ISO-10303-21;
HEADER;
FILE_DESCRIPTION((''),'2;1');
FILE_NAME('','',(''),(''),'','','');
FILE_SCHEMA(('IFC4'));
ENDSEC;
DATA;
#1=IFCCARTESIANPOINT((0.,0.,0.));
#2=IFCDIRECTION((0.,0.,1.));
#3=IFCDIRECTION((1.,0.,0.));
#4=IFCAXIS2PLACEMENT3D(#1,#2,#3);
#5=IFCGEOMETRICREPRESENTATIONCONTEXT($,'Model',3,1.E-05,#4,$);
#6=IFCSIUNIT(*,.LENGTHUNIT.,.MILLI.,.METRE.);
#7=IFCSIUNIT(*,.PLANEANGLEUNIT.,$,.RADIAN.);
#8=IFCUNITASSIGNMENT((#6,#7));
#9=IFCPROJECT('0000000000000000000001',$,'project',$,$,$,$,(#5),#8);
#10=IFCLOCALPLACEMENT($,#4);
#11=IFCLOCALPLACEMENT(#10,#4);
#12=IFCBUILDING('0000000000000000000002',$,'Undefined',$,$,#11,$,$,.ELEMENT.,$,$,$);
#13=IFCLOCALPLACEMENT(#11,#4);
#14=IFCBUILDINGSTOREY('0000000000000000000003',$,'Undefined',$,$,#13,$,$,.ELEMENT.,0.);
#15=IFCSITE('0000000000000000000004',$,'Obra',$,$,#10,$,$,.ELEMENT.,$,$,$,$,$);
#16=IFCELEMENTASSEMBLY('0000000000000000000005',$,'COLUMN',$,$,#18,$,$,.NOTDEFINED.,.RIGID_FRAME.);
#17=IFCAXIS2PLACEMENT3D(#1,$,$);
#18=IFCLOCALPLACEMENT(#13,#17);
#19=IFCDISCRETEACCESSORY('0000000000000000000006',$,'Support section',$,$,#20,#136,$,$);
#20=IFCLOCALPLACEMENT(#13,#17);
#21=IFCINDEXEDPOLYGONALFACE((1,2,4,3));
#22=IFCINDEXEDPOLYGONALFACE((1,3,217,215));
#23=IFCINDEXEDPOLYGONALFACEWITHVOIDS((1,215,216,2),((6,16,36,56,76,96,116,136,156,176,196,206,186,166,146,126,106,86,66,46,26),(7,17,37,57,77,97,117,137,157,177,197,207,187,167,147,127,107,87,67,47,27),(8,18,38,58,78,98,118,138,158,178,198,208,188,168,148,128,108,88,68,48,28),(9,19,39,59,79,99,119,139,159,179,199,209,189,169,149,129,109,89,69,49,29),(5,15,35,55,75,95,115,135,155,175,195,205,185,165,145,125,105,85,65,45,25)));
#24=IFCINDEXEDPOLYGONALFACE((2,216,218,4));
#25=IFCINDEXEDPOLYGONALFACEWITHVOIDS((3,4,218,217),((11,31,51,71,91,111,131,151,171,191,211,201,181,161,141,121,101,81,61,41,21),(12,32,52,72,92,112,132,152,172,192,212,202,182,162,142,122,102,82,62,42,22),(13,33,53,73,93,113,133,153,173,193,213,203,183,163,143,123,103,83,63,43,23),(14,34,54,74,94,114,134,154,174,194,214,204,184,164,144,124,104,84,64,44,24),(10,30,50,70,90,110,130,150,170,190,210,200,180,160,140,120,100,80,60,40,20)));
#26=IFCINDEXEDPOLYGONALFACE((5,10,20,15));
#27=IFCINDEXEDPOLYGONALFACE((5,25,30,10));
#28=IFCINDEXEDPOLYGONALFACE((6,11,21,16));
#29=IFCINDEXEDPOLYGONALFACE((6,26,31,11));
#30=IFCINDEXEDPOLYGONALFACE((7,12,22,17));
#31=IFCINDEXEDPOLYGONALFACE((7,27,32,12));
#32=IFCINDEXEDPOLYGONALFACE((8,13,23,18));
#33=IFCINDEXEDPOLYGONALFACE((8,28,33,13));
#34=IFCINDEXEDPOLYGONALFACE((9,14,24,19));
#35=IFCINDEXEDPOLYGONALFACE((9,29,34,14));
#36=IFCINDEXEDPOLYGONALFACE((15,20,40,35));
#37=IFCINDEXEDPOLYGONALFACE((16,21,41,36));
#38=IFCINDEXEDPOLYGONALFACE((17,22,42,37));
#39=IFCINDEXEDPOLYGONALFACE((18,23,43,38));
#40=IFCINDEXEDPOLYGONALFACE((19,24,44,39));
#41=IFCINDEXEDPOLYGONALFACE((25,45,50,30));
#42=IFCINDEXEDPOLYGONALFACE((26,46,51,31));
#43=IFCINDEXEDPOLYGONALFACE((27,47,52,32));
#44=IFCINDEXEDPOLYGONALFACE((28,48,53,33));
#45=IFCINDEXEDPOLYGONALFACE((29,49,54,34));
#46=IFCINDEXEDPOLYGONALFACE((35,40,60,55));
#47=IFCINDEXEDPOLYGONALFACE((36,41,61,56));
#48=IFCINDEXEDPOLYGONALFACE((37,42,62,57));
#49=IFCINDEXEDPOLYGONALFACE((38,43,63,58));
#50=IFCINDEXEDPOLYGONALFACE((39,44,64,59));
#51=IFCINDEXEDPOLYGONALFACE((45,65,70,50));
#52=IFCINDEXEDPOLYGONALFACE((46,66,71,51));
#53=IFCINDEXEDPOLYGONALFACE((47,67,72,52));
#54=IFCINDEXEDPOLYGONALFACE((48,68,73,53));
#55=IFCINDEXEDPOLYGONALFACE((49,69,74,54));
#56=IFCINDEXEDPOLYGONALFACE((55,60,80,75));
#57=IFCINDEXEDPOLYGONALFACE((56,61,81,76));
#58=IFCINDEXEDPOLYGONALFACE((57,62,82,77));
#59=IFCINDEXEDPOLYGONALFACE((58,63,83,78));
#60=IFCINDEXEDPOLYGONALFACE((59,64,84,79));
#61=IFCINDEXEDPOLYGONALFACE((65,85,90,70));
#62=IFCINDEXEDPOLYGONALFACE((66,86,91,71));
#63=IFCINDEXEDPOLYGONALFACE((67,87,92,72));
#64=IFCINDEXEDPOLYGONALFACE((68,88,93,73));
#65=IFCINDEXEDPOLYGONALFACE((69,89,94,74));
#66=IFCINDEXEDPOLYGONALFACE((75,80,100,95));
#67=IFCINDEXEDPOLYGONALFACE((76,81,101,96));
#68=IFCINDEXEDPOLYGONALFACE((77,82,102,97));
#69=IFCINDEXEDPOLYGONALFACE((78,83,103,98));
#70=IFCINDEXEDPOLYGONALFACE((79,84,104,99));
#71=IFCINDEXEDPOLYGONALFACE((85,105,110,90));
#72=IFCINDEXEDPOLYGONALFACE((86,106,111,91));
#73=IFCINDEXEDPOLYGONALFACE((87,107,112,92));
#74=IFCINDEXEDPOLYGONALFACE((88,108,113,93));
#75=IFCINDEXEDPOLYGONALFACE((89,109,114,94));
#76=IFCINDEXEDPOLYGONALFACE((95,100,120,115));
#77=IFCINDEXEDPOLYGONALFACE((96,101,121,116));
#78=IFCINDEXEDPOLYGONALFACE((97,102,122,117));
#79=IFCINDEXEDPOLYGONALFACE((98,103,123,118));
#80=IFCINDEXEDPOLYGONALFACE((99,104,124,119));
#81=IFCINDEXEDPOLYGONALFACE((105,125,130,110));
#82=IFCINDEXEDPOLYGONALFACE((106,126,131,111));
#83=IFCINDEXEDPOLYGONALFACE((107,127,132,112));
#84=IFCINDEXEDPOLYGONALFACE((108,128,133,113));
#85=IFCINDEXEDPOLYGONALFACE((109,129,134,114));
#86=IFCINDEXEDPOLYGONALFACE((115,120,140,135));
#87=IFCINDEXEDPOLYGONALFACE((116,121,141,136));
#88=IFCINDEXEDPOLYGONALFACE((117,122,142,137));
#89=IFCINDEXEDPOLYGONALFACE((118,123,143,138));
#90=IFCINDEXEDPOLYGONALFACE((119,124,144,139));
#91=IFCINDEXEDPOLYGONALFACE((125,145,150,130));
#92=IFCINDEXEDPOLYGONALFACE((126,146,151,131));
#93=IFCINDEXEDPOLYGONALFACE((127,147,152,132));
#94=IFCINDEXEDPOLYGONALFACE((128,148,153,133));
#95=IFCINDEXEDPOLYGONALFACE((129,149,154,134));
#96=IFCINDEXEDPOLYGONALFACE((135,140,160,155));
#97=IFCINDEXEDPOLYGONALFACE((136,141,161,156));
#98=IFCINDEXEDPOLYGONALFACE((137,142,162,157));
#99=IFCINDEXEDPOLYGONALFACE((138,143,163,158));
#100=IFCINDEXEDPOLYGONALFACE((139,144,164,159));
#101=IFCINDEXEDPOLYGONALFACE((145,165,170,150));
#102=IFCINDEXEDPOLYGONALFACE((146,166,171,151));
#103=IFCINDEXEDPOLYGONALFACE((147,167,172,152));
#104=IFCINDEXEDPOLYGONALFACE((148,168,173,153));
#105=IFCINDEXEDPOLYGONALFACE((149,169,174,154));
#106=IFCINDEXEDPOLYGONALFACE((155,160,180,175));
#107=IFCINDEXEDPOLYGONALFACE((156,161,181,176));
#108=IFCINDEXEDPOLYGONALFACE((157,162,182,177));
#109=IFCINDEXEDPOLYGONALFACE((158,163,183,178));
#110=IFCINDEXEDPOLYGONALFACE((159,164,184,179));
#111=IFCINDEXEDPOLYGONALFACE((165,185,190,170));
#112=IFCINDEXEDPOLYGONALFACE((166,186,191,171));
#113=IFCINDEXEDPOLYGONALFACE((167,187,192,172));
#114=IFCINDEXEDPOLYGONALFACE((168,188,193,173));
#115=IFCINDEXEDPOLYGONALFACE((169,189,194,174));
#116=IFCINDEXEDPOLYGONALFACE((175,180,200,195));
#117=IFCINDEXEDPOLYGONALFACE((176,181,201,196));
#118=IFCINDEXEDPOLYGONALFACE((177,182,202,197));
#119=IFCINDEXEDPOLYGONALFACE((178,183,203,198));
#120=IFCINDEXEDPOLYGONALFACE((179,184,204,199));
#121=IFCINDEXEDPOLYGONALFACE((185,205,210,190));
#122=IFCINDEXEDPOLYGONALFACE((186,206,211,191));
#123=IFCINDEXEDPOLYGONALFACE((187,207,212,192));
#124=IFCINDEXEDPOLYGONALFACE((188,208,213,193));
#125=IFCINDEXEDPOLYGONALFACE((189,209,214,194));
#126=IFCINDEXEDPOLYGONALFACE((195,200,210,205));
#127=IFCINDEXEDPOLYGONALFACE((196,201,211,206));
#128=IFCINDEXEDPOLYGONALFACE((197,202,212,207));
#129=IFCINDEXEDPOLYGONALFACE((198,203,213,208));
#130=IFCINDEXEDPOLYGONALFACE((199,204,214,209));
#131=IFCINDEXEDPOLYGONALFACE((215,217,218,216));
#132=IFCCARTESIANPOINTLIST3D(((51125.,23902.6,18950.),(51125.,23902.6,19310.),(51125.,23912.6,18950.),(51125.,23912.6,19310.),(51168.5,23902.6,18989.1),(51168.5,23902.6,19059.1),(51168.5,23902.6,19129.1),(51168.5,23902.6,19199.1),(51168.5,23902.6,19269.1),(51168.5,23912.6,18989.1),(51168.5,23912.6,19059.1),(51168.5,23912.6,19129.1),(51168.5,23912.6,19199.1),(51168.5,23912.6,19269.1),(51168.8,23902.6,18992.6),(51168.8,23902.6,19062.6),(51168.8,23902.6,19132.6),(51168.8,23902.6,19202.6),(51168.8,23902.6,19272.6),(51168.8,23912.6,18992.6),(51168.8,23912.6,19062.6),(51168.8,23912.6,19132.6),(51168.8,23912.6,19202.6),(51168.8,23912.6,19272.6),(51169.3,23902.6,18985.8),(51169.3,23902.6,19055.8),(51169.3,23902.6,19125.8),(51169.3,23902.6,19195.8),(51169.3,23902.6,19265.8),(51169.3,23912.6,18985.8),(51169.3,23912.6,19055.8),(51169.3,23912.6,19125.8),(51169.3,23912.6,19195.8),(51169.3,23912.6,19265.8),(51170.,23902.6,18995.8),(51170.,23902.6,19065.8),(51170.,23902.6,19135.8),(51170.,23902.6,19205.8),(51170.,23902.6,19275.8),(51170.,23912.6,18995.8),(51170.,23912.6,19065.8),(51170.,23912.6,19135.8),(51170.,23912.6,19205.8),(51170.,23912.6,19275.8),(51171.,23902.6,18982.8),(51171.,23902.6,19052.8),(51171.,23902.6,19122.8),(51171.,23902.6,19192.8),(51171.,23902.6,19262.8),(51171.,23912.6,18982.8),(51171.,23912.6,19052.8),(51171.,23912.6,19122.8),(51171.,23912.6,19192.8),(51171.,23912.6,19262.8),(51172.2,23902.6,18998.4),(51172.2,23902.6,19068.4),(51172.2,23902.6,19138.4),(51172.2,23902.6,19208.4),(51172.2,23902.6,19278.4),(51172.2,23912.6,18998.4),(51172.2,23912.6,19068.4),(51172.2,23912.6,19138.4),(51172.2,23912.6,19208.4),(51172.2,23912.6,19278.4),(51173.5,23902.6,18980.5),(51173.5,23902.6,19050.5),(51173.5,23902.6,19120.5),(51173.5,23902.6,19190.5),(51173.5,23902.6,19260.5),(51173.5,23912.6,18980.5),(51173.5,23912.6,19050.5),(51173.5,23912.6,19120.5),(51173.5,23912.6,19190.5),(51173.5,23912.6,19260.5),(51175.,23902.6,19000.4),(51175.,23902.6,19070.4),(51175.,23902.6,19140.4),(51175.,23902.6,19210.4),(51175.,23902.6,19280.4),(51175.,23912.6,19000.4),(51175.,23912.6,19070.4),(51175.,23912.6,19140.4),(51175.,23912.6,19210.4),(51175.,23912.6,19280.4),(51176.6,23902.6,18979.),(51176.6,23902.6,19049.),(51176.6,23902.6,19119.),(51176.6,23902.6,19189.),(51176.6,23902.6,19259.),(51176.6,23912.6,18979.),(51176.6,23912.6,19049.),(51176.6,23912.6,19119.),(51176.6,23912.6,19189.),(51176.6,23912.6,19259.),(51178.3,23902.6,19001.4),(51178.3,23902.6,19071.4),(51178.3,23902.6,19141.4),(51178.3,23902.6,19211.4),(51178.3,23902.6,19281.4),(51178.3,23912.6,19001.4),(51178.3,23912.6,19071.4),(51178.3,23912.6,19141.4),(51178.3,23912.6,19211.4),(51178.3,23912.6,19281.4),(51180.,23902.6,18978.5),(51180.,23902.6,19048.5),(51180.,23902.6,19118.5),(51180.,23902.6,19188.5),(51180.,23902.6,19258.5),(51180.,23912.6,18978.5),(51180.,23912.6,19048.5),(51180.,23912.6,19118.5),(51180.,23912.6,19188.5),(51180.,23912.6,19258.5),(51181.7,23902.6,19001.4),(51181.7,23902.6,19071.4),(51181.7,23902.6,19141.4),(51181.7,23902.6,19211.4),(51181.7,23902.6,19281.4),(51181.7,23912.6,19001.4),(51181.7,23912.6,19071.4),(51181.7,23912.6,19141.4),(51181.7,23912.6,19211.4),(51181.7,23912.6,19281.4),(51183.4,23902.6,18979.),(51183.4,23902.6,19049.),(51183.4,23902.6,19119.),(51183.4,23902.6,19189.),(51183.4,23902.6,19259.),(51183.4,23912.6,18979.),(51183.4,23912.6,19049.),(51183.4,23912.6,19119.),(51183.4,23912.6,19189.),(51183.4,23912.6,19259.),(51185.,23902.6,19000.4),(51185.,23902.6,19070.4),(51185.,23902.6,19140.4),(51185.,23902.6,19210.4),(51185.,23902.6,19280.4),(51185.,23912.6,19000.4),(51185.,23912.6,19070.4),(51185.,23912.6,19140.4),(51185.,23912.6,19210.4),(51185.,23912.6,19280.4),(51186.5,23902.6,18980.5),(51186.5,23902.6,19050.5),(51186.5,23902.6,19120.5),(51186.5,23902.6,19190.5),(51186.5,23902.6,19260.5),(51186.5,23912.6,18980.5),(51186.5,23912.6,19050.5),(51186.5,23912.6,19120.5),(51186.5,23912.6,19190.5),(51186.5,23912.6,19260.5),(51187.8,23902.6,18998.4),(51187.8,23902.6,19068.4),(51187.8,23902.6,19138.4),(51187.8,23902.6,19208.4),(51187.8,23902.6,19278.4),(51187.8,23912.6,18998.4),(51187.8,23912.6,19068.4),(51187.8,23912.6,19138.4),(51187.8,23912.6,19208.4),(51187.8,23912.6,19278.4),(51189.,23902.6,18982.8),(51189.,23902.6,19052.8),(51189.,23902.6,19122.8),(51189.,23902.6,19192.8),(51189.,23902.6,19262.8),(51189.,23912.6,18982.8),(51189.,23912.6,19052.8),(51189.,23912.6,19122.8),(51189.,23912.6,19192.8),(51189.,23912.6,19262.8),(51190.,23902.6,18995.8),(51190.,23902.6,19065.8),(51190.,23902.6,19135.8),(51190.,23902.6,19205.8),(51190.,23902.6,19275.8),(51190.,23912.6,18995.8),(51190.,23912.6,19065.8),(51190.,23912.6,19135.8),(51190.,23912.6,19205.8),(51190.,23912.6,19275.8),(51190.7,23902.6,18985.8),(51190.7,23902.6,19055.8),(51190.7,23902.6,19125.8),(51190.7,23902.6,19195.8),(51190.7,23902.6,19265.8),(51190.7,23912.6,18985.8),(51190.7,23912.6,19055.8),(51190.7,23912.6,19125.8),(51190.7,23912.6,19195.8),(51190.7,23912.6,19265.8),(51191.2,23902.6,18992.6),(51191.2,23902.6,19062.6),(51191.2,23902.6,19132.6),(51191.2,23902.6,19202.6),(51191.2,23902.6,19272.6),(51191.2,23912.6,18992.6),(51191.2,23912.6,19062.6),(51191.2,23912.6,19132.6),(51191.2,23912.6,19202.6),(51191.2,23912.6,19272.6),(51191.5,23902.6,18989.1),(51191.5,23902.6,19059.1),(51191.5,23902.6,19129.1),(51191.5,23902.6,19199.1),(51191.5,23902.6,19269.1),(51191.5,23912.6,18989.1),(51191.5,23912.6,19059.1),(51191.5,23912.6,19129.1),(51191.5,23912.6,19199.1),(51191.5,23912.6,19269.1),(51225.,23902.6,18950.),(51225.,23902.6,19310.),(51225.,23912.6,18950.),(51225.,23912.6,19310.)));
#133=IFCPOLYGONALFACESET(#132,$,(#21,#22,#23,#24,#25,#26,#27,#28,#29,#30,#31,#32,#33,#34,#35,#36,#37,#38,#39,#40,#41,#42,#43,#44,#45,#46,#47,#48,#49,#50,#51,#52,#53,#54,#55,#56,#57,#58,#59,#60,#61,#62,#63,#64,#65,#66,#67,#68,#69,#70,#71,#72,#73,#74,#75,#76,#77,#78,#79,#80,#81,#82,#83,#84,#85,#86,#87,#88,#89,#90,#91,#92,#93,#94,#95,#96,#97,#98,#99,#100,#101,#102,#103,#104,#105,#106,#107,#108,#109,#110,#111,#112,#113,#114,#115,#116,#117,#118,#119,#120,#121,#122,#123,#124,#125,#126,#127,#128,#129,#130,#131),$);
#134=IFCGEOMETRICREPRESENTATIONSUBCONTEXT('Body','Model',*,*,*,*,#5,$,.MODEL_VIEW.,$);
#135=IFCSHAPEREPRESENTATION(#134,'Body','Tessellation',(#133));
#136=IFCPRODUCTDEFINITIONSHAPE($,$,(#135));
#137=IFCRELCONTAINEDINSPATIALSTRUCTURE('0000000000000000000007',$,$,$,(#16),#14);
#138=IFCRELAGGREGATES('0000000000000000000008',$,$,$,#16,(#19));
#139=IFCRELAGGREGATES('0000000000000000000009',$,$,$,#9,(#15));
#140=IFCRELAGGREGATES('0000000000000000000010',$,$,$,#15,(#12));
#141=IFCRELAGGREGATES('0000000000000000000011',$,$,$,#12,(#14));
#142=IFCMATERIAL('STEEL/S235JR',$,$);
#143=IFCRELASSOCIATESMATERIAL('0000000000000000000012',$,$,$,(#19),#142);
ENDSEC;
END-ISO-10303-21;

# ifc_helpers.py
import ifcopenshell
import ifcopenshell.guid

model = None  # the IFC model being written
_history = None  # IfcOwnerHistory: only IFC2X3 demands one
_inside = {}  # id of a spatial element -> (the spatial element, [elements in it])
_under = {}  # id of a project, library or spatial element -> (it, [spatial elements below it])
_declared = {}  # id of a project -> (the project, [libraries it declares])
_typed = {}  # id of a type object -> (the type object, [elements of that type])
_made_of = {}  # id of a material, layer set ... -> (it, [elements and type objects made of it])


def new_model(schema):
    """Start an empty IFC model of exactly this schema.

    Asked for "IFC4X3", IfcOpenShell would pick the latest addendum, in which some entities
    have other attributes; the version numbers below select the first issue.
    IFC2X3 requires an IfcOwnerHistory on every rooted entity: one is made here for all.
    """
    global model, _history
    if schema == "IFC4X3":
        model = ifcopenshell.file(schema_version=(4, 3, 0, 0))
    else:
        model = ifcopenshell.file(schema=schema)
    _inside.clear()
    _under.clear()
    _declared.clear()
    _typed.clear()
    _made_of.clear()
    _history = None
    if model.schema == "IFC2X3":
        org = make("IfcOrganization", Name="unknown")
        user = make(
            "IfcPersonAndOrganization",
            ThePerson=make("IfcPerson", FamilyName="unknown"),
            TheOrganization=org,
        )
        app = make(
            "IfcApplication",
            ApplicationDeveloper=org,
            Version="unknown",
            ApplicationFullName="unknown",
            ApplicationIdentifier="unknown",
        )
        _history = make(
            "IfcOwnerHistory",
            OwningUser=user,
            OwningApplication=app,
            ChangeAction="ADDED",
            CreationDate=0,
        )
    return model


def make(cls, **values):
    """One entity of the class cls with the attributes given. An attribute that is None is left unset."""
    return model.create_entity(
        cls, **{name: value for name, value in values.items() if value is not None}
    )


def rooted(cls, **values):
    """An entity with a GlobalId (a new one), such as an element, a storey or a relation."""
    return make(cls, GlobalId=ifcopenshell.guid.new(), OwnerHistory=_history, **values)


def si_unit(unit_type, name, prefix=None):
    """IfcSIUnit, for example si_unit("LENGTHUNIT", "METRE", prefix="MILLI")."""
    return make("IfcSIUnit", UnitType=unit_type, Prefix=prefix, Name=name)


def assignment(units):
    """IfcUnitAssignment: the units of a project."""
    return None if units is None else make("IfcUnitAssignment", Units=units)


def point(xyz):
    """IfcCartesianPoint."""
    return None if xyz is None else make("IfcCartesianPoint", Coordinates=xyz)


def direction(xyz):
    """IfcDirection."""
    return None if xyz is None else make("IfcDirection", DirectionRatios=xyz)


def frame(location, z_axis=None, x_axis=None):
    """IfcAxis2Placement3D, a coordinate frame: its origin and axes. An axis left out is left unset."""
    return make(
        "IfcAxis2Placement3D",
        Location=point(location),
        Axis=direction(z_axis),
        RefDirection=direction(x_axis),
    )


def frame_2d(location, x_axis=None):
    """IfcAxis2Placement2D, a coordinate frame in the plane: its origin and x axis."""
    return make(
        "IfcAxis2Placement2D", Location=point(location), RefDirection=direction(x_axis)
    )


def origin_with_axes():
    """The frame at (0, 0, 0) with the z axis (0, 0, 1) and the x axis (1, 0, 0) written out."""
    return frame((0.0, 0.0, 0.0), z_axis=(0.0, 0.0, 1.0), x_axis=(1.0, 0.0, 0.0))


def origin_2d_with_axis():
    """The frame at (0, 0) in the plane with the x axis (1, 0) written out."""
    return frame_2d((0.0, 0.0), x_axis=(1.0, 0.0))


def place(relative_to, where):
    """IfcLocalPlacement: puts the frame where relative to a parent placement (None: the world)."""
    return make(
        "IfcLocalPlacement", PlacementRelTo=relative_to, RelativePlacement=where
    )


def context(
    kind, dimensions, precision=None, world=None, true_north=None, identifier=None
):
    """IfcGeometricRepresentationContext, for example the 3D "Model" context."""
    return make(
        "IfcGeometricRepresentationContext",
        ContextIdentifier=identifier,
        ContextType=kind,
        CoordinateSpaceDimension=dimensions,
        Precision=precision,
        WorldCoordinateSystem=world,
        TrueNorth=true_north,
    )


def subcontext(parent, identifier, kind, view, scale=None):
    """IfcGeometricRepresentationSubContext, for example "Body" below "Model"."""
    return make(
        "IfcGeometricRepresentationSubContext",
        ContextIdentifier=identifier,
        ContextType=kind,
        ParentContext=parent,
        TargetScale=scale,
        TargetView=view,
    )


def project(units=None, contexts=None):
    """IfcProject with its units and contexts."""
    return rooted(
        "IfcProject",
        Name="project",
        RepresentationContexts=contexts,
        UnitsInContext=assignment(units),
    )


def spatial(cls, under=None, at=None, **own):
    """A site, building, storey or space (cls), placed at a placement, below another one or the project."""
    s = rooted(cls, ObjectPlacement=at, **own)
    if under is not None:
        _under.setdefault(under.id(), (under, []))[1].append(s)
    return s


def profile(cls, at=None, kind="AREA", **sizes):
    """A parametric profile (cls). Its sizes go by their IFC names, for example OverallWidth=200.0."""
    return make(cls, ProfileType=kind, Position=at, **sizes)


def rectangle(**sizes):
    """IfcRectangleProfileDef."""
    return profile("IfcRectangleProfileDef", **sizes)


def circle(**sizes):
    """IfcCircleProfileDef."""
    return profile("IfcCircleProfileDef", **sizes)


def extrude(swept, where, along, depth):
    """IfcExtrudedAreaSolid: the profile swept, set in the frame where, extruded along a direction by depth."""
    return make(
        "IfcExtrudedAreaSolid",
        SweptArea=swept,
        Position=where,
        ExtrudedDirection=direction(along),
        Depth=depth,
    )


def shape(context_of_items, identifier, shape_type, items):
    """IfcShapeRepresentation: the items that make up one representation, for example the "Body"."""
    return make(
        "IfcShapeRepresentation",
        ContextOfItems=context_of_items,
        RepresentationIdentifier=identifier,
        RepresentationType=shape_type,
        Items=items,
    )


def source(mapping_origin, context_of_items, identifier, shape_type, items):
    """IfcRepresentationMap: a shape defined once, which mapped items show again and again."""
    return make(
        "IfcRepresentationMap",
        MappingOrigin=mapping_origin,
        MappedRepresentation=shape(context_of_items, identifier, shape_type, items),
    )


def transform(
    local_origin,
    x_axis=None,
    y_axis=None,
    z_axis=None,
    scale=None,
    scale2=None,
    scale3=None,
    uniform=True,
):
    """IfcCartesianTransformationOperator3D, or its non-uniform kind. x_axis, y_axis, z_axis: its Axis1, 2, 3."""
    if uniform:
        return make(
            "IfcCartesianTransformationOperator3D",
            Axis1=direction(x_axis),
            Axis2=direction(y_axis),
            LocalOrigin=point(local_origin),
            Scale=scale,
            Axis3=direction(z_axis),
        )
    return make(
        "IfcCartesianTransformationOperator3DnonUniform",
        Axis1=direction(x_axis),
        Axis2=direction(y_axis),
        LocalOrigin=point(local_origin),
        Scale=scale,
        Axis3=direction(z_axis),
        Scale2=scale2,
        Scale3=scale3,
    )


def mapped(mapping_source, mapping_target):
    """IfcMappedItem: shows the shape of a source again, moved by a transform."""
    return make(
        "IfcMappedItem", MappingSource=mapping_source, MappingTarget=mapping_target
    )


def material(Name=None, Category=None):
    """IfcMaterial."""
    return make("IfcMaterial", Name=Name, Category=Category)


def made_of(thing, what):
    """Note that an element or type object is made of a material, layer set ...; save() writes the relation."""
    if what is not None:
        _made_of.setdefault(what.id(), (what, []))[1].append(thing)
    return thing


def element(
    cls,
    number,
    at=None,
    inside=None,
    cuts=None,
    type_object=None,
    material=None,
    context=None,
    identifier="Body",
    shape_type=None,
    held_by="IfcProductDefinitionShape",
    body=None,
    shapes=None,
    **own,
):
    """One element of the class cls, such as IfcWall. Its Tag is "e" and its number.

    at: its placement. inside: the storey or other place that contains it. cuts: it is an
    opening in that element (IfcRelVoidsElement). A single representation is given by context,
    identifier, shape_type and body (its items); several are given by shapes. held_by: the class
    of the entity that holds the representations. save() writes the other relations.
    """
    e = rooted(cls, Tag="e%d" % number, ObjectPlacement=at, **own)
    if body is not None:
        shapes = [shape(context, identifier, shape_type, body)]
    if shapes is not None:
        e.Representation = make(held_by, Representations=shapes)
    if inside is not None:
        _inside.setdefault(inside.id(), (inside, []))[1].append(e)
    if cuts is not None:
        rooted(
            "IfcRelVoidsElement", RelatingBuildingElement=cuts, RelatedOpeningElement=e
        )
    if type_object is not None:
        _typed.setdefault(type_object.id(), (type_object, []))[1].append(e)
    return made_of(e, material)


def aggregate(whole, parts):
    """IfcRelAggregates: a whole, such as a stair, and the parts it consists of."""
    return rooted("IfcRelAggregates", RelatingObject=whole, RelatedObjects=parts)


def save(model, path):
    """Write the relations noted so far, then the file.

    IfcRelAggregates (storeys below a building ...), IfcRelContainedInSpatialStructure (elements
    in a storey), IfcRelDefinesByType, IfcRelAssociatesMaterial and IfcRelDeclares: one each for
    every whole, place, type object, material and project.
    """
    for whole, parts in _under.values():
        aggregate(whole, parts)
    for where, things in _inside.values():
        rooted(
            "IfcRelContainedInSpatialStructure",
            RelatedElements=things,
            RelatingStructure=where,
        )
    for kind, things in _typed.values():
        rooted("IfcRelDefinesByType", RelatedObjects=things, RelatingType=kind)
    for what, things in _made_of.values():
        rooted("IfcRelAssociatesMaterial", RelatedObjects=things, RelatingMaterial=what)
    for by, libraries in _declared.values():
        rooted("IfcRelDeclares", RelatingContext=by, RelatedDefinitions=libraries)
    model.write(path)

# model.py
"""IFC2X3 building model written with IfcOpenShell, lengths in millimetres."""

from ifc_helpers import new_model, si_unit, frame, origin_with_axes, origin_2d_with_axis, place, context, subcontext, project, spatial, rectangle, circle, extrude, source, transform, mapped, material, element, aggregate, save


model = new_model("IFC2X3")

# Units and contexts
model_context = context("Model", 3, precision=1e-05, world=origin_with_axes())
body_context = subcontext(model_context, "Body", "Model", "MODEL_VIEW")
ifc_project = project(units=[si_unit("LENGTHUNIT", "METRE", prefix="MILLI"), si_unit("PLANEANGLEUNIT", "RADIAN")], contexts=[model_context])

# Site, building, storey
site_placement = place(None, origin_with_axes())
site = spatial("IfcSite", under=ifc_project, at=site_placement, Name="Obra", CompositionType="ELEMENT")
building_placement = place(site_placement, origin_with_axes())
building = spatial("IfcBuilding", under=site, at=building_placement, Name="Undefined", CompositionType="ELEMENT")
storey_placement = place(building_placement, origin_with_axes())
storey = spatial("IfcBuildingStorey", under=building, at=storey_placement, Name="Undefined", CompositionType="ELEMENT", Elevation=0.0)

# Shared definitions
ifc_material_1 = material(Name="STEEL/S235JR")

# Element assembly, discrete accessory, opening
assembly_1_placement = place(storey_placement, origin_with_axes())
assembly_1 = element("IfcElementAssembly", 1, at=assembly_1_placement, inside=storey, Name="COLUMN", AssemblyPlace="NOTDEFINED", PredefinedType="RIGID_FRAME")
discrete_accessory_1_placement = place(assembly_1_placement, frame((51175.0, 23907.6, 18950.0), z_axis=(0.0, 0.0, 1.0), x_axis=(-1.0, 0.0, 0.0)))
discrete_accessory_1 = element("IfcDiscreteAccessory", 2, at=discrete_accessory_1_placement, material=ifc_material_1, Name="Support section", context=body_context, shape_type="SweptSolid", body=[
    extrude(rectangle(XDim=10.0, YDim=100.0, at=origin_2d_with_axis()), frame((0.0, 0.0, 360.0), z_axis=(0.0, 0.0, -1.0), x_axis=(0.0, 1.0, 0.0)), (0.0, 0.0, 1.0), 360.0),
])
shared_shape_1 = source(origin_with_axes(), body_context, "Body", "SweptSolid", [
    extrude(circle(Radius=11.5, at=origin_2d_with_axis()), frame((0.0, 5.7, 0.0), z_axis=(0.0, 1.0, 0.0), x_axis=(1.0, 0.0, 0.0)), (0.0, 0.0, 1.0), 10.2),
])
opening_1_placement = place(assembly_1_placement, frame((51135.0, 23896.9, 19350.0), z_axis=(1.0, 0.0, 0.0), x_axis=(0.0, 0.0, -1.0)))
element("IfcOpeningElement", 3, at=opening_1_placement, cuts=discrete_accessory_1, ObjectType="Opening", context=body_context, shape_type="MappedRepresentation", body=[
    mapped(shared_shape_1, transform((80.0, 0.0, 45.0))),
    mapped(shared_shape_1, transform((150.0, 0.0, 45.0))),
    mapped(shared_shape_1, transform((220.0, 0.0, 45.0))),
    mapped(shared_shape_1, transform((290.0, 0.0, 45.0))),
    mapped(shared_shape_1, transform((360.0, 0.0, 45.0))),
])
aggregate(assembly_1, [discrete_accessory_1])

save(model, "model.ifc")
